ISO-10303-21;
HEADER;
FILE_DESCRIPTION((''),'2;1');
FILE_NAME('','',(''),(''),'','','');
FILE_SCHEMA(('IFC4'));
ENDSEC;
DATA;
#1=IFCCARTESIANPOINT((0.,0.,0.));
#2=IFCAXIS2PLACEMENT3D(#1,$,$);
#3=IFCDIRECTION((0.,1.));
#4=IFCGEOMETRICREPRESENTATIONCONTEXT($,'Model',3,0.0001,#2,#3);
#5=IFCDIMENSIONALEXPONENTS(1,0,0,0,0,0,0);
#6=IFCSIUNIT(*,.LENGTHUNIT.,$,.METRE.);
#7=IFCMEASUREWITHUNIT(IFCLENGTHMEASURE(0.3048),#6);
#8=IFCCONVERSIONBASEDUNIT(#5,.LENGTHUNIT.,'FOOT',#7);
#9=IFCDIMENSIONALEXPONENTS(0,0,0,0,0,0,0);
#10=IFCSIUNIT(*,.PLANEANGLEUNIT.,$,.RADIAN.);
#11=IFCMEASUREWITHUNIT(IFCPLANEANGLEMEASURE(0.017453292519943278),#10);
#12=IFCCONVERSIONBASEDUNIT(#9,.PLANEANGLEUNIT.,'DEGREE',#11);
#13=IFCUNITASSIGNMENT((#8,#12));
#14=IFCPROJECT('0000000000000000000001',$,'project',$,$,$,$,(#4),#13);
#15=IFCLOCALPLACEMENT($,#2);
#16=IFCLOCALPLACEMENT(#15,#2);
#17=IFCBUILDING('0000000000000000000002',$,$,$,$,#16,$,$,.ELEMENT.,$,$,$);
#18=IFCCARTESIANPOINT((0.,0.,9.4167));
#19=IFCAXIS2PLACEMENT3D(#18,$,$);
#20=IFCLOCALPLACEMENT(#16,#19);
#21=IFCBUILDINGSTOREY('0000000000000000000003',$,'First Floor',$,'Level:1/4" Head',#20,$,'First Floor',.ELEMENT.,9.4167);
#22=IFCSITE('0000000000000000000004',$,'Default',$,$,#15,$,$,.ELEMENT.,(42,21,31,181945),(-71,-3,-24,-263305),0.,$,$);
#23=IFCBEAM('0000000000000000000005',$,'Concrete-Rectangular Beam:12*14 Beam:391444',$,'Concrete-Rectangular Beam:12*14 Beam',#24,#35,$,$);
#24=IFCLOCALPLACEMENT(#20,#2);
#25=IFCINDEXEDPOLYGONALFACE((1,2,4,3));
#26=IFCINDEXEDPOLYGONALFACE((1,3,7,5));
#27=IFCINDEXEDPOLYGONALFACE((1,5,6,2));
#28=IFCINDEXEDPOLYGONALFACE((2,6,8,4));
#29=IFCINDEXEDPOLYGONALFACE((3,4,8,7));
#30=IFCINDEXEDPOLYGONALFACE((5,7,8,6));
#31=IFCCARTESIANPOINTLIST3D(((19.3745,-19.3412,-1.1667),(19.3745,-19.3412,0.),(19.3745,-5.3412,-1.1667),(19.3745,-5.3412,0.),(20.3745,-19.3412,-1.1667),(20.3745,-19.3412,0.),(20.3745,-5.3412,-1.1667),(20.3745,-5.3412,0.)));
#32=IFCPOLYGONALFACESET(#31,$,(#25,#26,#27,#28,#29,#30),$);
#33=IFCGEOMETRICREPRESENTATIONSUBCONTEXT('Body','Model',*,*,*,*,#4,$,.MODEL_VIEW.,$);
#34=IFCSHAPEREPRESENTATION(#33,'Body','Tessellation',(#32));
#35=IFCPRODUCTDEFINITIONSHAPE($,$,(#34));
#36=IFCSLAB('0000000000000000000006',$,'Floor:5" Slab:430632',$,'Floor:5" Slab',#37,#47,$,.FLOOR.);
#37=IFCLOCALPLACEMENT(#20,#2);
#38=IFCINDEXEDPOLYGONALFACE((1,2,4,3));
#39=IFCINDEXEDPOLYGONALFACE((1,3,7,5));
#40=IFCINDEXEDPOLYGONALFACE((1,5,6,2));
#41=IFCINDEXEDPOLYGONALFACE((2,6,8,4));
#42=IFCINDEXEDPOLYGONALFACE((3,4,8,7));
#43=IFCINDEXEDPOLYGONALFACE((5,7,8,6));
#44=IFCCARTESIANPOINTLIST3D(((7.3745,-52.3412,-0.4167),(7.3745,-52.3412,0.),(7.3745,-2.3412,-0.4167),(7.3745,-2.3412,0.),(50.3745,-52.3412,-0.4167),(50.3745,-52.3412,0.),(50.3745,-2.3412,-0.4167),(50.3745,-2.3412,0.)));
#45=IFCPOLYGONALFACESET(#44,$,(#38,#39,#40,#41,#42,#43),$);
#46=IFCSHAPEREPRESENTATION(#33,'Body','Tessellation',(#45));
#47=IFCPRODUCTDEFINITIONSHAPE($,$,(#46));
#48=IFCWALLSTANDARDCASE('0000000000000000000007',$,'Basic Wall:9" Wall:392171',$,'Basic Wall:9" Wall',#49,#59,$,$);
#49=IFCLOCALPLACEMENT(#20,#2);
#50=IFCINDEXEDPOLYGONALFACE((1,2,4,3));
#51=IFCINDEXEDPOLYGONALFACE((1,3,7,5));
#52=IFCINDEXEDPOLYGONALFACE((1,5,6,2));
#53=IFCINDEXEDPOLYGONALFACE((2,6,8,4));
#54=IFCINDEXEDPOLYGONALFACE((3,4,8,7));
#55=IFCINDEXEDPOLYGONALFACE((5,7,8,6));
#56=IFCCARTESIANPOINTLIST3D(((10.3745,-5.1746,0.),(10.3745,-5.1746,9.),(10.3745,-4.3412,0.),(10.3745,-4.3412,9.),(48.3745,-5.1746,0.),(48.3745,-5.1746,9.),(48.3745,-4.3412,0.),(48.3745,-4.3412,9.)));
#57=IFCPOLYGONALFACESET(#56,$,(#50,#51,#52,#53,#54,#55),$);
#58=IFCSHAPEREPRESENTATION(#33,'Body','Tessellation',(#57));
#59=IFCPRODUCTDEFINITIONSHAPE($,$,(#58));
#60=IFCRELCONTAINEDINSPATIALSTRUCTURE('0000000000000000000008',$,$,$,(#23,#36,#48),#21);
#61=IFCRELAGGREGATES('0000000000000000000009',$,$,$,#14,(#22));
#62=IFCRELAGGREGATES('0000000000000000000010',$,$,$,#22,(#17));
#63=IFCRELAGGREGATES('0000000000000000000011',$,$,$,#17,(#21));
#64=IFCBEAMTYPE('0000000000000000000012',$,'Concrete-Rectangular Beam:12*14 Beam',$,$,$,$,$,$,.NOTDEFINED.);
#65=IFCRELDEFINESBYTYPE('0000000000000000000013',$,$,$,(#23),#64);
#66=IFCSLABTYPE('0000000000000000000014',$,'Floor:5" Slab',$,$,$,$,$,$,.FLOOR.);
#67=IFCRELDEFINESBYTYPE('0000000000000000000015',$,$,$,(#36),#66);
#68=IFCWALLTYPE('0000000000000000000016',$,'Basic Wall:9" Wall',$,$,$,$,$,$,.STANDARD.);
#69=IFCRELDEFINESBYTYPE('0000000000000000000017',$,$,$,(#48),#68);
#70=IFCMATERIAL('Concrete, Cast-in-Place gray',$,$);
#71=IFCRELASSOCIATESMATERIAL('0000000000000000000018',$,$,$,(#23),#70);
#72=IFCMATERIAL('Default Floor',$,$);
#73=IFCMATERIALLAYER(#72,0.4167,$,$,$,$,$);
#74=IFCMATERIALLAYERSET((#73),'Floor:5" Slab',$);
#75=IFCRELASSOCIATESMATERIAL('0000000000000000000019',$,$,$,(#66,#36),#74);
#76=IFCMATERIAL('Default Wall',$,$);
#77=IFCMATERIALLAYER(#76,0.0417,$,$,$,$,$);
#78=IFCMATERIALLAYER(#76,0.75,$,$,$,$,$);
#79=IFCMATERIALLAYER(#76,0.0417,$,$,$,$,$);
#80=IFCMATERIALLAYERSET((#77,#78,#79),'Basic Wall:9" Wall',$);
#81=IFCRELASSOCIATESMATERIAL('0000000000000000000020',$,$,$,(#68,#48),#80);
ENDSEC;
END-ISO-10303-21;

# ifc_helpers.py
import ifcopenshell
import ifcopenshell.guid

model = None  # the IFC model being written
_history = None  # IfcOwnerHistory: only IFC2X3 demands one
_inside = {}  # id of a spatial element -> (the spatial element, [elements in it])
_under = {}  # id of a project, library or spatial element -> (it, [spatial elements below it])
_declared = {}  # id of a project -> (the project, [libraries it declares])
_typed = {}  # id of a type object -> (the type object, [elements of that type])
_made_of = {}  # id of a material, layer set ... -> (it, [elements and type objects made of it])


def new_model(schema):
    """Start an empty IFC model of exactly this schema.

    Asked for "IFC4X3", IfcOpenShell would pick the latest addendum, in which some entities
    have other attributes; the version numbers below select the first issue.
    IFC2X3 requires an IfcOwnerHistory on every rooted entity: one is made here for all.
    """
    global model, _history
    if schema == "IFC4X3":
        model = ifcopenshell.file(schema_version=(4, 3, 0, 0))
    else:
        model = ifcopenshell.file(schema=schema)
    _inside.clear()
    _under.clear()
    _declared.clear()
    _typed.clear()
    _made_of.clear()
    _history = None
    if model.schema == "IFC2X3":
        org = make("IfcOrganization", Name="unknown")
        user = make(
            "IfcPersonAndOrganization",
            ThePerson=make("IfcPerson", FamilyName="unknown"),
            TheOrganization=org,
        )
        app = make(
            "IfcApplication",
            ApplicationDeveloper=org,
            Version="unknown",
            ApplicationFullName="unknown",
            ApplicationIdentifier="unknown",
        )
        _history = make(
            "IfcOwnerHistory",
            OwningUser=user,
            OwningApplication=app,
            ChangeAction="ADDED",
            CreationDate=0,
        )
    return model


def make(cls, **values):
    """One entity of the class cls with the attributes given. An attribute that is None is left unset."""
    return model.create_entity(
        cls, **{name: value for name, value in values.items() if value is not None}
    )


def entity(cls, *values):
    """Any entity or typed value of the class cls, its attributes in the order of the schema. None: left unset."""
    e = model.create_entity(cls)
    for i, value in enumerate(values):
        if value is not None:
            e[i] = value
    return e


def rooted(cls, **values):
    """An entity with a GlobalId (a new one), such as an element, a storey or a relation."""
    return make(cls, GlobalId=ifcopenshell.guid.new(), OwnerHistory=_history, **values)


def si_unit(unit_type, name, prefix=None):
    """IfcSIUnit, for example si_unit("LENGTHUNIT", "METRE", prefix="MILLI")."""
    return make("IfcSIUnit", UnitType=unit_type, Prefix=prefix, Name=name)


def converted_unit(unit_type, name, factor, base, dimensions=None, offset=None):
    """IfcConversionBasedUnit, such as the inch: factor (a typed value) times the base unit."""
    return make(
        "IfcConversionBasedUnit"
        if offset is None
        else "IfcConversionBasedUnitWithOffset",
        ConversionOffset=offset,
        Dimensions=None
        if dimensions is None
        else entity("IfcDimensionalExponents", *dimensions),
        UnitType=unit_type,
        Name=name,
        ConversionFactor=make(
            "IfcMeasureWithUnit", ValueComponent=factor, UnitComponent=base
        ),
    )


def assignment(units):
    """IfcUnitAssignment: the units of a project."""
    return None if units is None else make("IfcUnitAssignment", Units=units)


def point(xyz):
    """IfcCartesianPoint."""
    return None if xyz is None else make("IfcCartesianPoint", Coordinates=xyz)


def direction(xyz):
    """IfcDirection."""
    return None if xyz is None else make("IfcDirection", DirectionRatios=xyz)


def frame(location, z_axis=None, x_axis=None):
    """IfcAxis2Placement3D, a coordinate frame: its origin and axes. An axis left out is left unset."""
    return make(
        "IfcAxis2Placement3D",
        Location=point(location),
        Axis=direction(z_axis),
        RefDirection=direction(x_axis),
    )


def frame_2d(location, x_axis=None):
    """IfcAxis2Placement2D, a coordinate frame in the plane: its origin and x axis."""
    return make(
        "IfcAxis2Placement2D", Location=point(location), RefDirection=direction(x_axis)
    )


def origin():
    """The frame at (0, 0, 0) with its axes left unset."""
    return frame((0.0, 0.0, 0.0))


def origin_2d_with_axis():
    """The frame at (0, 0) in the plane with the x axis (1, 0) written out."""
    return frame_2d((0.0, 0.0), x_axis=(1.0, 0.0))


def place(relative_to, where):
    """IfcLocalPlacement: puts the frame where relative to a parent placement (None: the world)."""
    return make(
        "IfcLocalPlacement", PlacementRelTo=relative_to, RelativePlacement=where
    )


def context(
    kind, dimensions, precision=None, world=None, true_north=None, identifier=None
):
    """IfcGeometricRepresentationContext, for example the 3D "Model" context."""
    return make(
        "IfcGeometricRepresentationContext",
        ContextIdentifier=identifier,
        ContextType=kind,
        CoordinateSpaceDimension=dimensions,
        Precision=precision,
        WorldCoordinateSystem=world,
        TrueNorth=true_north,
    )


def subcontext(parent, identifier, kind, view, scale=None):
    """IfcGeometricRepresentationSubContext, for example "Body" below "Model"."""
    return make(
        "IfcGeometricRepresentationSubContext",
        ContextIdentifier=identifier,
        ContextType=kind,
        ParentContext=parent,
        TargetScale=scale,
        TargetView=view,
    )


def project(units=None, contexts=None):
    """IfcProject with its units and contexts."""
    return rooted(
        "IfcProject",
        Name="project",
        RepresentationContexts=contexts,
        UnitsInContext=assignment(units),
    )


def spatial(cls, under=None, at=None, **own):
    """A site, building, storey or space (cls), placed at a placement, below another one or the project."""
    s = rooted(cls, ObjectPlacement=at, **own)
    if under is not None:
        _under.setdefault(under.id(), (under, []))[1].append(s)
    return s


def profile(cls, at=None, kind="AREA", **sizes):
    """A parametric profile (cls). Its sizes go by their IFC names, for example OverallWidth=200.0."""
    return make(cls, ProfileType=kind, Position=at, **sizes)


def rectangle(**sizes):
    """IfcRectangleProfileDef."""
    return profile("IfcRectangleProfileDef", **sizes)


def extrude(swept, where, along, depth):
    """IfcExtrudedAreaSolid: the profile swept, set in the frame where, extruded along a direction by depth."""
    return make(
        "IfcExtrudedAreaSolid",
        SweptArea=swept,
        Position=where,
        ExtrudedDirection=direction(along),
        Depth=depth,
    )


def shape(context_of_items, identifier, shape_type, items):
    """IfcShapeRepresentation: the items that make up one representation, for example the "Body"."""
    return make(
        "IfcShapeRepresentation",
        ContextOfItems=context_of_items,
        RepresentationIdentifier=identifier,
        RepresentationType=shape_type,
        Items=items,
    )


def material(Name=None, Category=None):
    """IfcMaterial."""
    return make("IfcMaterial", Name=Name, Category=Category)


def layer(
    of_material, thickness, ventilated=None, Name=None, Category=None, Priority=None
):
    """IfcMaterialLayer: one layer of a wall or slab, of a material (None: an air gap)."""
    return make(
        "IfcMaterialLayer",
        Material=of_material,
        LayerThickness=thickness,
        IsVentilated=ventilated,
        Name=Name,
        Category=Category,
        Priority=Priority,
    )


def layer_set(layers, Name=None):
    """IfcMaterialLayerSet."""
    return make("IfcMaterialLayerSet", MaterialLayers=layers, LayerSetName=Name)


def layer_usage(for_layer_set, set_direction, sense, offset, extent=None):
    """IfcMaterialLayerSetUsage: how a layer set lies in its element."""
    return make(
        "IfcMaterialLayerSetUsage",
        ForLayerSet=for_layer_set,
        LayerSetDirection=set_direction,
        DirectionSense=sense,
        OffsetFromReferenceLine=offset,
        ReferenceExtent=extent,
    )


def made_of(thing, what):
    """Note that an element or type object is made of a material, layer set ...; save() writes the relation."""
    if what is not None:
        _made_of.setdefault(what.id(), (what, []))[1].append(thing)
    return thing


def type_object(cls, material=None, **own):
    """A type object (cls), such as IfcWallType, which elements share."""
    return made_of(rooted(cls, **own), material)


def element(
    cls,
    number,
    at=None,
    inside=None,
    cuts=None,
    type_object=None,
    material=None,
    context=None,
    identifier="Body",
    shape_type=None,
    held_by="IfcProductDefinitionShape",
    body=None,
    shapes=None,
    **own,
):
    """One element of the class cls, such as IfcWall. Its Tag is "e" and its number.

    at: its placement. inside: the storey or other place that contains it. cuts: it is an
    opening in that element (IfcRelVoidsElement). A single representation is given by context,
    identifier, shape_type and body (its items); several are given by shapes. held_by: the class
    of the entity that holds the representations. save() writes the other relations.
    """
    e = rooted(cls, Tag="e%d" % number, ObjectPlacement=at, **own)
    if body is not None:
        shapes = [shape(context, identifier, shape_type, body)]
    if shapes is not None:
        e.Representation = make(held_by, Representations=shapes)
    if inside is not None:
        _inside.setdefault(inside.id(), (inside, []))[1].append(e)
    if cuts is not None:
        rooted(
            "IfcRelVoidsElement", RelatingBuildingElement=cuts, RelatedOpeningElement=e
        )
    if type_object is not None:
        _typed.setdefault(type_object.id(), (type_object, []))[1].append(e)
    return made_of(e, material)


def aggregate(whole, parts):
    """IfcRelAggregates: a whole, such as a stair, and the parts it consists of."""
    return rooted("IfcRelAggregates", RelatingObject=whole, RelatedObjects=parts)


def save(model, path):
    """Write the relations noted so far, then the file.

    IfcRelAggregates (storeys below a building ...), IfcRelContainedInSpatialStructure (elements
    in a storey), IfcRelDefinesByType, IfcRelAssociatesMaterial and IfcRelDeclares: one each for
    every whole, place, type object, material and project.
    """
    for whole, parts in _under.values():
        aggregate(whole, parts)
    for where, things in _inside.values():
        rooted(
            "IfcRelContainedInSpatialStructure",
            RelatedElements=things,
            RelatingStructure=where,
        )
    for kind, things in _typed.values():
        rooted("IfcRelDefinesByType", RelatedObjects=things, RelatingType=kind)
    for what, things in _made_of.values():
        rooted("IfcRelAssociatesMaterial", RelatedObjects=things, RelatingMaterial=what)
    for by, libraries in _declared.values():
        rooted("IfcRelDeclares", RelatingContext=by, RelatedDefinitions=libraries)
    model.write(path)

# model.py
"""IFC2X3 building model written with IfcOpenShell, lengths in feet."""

from ifc_helpers import new_model, entity, si_unit, converted_unit, direction, frame, frame_2d, origin, origin_2d_with_axis, place, context, subcontext, project, spatial, rectangle, extrude, material, layer, layer_set, layer_usage, type_object, element, save


model = new_model("IFC2X3")

# Units and contexts
model_context = context("Model", 3, precision=0.0001, world=origin(), true_north=direction((0.0, 1.0)))
body_context = subcontext(model_context, "Body", "Model", "MODEL_VIEW")
ifc_project = project(units=[converted_unit("LENGTHUNIT", "FOOT", entity("IfcLengthMeasure", 0.3048), si_unit("LENGTHUNIT", "METRE"), dimensions=[1, 0, 0, 0, 0, 0, 0]), converted_unit("PLANEANGLEUNIT", "DEGREE", entity("IfcPlaneAngleMeasure", 0.017453292519943278), si_unit("PLANEANGLEUNIT", "RADIAN"), dimensions=[0, 0, 0, 0, 0, 0, 0])], contexts=[model_context])

# Site, building, storey
site_placement = place(None, origin())
site = spatial("IfcSite", under=ifc_project, at=site_placement, Name="Default", CompositionType="ELEMENT", RefLatitude=(42, 21, 31, 181945), RefLongitude=(-71, -3, -24, -263305), RefElevation=0.0)
building_placement = place(site_placement, origin())
building = spatial("IfcBuilding", under=site, at=building_placement, CompositionType="ELEMENT")
storey_placement = place(building_placement, frame((0.0, 0.0, 9.4167)))
storey = spatial("IfcBuildingStorey", under=building, at=storey_placement, Name="First Floor", ObjectType="Level:1/4\" Head", LongName="First Floor", CompositionType="ELEMENT", Elevation=9.4167)

# Shared definitions
ifc_material_1 = material(Name="Concrete, Cast-in-Place gray")

# Beam
beam_type = type_object("IfcBeamType", Name="Concrete-Rectangular Beam:12*14 Beam", PredefinedType="NOTDEFINED")
beam_placement = place(storey_placement, frame((19.8745, -4.8412, 0.0), z_axis=(0.0, 0.0, 1.0), x_axis=(0.0, -1.0, 0.0)))
element("IfcBeam", 1, at=beam_placement, inside=storey, type_object=beam_type, material=ifc_material_1, Name="Concrete-Rectangular Beam:12*14 Beam:391444", ObjectType="Concrete-Rectangular Beam:12*14 Beam", context=body_context, shape_type="SweptSolid", body=[
    extrude(rectangle(XDim=1.1667, YDim=1.0, at=frame_2d((0.0, 0.0), x_axis=(1.0, 0.0))), frame((0.5, 0.0, -0.5833), z_axis=(1.0, 0.0, 0.0), x_axis=(0.0, 0.0, -1.0)), (0.0, 0.0, 1.0), 14.0),
])

# Slab
ifc_material_2 = material(Name="Default Floor")
ifc_layer_1 = layer(ifc_material_2, 0.4167)
ifc_layer_set_1 = layer_set([ifc_layer_1], Name="Floor:5\" Slab")
ifc_layer_usage_1 = layer_usage(ifc_layer_set_1, "AXIS3", "POSITIVE", 0.0)
slab_type = type_object("IfcSlabType", Name="Floor:5\" Slab", PredefinedType="FLOOR", material=ifc_layer_set_1)
slab_placement = place(storey_placement, origin())
element("IfcSlab", 2, at=slab_placement, inside=storey, type_object=slab_type, material=ifc_layer_usage_1, Name="Floor:5\" Slab:430632", ObjectType="Floor:5\" Slab", PredefinedType="FLOOR", context=body_context, shape_type="SweptSolid", body=[
    extrude(rectangle(XDim=50.0, YDim=43.0, at=origin_2d_with_axis()), frame((28.8745, -27.3412, 0.0), z_axis=(0.0, 0.0, -1.0), x_axis=(0.0, 1.0, 0.0)), (0.0, 0.0, 1.0), 0.4167),
])

# Wall
ifc_material_3 = material(Name="Default Wall")
ifc_layer_2 = layer(ifc_material_3, 0.0417)
ifc_layer_3 = layer(ifc_material_3, 0.75)
ifc_layer_4 = layer(ifc_material_3, 0.0417)
ifc_layer_set_2 = layer_set([ifc_layer_2, ifc_layer_3, ifc_layer_4], Name="Basic Wall:9\" Wall")
ifc_layer_usage_2 = layer_usage(ifc_layer_set_2, "AXIS2", "NEGATIVE", 0.4167)
wall_type = type_object("IfcWallType", Name="Basic Wall:9\" Wall", PredefinedType="STANDARD", material=ifc_layer_set_2)
wall_placement = place(storey_placement, frame((10.3745, -4.7579, 0.0)))
element("IfcWallStandardCase", 3, at=wall_placement, inside=storey, type_object=wall_type, material=ifc_layer_usage_2, Name="Basic Wall:9\" Wall:392171", ObjectType="Basic Wall:9\" Wall", context=body_context, shape_type="SweptSolid", body=[
    extrude(rectangle(XDim=38.0, YDim=0.8333, at=frame_2d((19.0, 0.0), x_axis=(-1.0, 0.0))), origin(), (0.0, 0.0, 1.0), 9.0),
])

save(model, "model.ifc")
